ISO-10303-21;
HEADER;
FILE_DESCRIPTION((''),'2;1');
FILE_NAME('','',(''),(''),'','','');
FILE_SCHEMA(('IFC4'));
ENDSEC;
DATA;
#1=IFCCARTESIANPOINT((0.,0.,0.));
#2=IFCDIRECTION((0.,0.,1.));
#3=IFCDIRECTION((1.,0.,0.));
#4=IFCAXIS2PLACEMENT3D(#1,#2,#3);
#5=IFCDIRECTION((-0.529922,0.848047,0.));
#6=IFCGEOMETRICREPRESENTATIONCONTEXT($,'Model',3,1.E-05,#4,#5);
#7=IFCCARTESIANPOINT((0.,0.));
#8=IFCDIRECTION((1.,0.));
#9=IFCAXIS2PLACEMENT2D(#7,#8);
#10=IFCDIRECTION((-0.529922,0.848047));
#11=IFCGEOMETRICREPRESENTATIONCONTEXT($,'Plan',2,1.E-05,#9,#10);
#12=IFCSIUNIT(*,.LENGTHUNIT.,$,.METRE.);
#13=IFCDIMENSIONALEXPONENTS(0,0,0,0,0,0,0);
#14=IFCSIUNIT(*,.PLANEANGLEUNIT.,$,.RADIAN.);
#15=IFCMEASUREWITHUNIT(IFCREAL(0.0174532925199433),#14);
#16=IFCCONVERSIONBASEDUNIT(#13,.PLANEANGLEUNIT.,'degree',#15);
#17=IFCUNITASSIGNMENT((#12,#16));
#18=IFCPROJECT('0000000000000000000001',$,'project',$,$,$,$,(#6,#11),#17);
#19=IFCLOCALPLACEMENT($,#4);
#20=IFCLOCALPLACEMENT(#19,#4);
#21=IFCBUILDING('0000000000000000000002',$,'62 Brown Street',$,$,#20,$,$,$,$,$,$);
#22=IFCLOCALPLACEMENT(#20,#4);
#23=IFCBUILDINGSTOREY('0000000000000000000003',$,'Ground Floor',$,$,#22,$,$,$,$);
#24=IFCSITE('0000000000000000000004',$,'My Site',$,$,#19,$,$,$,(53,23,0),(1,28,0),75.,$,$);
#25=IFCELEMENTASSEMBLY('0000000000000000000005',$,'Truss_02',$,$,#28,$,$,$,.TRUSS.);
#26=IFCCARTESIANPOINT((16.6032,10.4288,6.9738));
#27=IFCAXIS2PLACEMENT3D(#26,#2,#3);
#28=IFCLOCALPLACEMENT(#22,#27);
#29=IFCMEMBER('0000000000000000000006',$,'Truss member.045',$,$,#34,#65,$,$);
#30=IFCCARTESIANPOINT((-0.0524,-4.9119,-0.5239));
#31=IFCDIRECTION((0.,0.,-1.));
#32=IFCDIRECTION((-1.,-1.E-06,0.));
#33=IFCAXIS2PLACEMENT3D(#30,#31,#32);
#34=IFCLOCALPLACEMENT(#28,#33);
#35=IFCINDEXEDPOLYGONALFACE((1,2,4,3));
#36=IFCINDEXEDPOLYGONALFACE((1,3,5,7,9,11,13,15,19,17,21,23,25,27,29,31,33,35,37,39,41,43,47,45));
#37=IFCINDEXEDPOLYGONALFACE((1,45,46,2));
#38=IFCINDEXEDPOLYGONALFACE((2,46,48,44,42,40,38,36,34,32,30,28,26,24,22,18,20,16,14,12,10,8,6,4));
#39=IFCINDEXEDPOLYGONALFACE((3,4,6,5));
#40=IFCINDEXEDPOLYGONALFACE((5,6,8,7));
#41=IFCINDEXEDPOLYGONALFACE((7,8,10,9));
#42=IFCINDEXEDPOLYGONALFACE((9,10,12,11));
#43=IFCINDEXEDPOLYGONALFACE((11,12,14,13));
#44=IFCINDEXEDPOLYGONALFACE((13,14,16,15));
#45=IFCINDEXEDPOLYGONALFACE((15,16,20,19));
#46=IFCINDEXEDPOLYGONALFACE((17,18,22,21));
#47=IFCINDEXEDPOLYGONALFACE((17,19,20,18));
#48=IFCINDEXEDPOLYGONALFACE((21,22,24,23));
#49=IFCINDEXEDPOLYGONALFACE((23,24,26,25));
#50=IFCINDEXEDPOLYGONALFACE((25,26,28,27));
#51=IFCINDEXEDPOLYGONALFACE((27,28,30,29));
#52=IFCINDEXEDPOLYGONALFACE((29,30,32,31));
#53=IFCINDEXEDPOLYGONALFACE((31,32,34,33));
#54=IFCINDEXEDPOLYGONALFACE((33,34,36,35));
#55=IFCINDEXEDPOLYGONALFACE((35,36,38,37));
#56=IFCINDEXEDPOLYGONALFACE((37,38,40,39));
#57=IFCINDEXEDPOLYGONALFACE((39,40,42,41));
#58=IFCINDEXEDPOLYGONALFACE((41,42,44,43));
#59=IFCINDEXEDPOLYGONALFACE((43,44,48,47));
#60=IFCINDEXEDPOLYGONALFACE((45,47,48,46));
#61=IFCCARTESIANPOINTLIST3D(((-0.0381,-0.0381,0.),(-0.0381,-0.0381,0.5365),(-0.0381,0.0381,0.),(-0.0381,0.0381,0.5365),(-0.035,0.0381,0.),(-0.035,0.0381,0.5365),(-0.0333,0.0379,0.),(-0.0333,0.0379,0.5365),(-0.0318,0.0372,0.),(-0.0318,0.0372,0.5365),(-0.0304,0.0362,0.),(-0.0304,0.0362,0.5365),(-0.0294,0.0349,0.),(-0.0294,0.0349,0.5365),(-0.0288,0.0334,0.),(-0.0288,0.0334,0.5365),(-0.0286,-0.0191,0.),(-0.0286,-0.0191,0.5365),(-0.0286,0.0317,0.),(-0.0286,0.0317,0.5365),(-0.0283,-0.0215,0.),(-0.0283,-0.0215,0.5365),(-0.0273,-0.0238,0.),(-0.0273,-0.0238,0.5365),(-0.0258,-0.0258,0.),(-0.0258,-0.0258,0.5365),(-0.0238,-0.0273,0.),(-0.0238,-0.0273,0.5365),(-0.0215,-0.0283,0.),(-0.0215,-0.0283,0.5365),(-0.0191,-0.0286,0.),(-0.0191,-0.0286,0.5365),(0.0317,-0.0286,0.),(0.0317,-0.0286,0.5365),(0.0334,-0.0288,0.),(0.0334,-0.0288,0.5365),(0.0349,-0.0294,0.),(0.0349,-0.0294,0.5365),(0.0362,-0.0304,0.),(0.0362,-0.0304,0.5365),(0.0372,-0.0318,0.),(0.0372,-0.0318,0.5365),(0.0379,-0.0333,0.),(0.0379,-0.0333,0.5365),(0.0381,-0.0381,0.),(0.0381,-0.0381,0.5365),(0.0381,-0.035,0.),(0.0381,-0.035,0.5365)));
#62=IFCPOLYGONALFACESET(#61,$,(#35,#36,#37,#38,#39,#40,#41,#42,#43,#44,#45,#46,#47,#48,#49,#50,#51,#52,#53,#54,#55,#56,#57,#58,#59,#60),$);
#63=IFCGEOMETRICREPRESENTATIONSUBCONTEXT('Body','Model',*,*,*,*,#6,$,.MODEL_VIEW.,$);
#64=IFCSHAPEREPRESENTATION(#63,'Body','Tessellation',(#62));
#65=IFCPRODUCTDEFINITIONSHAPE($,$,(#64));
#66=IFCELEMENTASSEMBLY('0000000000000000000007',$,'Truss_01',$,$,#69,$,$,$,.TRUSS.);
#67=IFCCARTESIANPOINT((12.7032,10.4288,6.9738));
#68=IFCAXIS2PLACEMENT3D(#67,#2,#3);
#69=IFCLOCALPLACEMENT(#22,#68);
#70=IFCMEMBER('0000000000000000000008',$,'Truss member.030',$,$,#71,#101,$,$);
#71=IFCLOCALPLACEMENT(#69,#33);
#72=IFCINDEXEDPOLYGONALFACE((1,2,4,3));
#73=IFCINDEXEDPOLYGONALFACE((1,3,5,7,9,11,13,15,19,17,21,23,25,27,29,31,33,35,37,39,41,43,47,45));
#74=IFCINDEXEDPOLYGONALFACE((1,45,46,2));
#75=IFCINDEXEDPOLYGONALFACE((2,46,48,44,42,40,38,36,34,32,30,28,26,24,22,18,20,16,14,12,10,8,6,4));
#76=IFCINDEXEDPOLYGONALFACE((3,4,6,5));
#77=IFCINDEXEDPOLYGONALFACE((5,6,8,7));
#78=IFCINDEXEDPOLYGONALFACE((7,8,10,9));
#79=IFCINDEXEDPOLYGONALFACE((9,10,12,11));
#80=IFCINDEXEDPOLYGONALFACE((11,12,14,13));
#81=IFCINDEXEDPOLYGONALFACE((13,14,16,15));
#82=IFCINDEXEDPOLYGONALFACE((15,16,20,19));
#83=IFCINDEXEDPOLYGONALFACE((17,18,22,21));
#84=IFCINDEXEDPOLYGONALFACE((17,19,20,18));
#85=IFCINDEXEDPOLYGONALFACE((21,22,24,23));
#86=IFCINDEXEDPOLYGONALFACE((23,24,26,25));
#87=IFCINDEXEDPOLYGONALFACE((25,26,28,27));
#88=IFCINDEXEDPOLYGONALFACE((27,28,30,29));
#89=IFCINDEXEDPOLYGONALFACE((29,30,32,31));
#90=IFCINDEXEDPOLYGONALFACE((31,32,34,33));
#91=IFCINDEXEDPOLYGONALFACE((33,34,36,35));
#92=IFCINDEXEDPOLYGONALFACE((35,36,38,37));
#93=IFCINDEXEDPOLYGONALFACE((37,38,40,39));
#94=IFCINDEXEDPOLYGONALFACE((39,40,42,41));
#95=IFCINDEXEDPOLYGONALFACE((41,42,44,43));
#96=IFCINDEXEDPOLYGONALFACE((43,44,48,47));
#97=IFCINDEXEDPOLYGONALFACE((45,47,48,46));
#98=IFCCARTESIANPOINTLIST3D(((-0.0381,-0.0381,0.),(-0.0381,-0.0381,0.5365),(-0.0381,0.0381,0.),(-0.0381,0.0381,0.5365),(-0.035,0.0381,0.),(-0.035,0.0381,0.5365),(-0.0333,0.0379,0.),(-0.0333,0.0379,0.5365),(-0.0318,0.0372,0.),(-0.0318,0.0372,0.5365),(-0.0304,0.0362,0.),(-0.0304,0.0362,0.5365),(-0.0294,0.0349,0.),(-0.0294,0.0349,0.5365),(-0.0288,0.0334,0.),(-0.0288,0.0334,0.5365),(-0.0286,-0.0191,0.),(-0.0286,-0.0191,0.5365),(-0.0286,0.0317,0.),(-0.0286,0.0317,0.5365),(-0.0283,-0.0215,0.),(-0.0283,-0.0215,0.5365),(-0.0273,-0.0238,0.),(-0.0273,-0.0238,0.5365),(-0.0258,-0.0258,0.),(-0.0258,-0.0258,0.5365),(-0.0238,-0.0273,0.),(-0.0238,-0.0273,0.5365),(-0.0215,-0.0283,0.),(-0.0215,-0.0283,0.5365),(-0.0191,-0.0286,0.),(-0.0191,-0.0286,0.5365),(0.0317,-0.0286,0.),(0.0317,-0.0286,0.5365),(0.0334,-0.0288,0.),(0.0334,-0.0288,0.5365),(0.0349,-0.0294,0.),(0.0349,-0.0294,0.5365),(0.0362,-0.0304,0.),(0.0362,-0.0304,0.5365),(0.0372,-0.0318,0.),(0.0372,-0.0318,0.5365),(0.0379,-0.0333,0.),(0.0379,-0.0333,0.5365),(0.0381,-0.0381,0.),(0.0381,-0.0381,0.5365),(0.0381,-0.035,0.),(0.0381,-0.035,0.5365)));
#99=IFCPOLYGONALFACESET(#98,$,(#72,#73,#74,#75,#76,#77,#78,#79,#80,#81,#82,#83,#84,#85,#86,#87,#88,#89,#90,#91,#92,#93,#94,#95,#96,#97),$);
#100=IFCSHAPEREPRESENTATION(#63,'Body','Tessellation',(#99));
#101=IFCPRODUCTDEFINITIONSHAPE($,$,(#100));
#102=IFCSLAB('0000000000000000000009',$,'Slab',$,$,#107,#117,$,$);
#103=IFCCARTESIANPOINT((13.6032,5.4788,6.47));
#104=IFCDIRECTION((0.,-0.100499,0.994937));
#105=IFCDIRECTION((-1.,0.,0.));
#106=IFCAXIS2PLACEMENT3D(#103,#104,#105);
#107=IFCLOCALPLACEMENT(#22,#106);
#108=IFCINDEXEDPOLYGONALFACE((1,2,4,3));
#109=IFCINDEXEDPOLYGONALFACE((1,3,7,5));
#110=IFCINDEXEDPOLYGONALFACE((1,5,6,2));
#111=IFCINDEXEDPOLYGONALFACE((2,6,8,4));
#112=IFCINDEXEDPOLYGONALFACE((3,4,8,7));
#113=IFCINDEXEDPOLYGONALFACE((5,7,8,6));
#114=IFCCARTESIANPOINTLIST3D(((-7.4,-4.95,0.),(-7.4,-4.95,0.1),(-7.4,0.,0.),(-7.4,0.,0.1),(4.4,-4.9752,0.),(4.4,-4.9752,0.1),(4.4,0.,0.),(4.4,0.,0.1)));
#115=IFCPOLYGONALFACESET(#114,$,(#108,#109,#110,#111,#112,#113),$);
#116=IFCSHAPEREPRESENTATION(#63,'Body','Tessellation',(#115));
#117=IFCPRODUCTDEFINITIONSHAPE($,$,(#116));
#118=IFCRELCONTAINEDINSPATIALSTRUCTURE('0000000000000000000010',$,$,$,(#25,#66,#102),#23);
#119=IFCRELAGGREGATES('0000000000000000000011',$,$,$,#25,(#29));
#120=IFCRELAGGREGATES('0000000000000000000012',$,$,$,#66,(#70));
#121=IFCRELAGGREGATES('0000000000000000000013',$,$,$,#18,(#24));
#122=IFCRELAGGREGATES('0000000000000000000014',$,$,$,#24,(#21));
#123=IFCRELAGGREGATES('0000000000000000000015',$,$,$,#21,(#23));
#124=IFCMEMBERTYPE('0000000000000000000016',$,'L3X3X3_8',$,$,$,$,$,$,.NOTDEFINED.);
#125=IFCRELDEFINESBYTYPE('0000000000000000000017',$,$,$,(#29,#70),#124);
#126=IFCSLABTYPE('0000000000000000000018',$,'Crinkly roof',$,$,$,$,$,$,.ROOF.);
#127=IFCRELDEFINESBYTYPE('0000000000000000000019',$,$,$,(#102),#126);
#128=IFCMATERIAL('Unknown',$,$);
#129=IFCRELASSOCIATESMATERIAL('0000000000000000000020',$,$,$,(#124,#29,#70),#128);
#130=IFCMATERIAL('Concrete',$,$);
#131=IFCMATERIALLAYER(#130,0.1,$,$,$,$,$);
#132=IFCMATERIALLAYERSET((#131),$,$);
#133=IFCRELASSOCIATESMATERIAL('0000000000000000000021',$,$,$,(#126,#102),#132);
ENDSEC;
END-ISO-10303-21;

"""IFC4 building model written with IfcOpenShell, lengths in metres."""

from ifc_helpers import new_model, entity, si_unit, converted_unit, direction, frame, origin_with_axes, origin_2d_with_axis, place, context, subcontext, project, spatial, indexed_curve, l_section, outline, extrude, material, layer, layer_set, layer_usage, material_profile, profile_set, profile_usage, type_object, element, aggregate, save


model = new_model("IFC4")

# Units and contexts
model_context = context("Model", 3, precision=1e-05, world=origin_with_axes(), true_north=direction((-0.529922, 0.848047, 0.0)))
plan_context = context("Plan", 2, precision=1e-05, world=origin_2d_with_axis(), true_north=direction((-0.529922, 0.848047)))
body_context_1 = subcontext(model_context, "Body", "Model", "MODEL_VIEW")
ifc_project = project(units=[si_unit("LENGTHUNIT", "METRE"), converted_unit("PLANEANGLEUNIT", "degree", entity("IfcReal", 0.0174532925199433), si_unit("PLANEANGLEUNIT", "RADIAN"), dimensions=[0, 0, 0, 0, 0, 0, 0])], contexts=[model_context, plan_context])

# Site, building, storey
site_placement = place(None, origin_with_axes())
site = spatial("IfcSite", under=ifc_project, at=site_placement, Name="My Site", RefLatitude=(53, 23, 0), RefLongitude=(1, 28, 0), RefElevation=75.0)
building_placement = place(site_placement, origin_with_axes())
building = spatial("IfcBuilding", under=site, at=building_placement, Name="62 Brown Street")
storey_placement = place(building_placement, origin_with_axes())
storey = spatial("IfcBuildingStorey", under=building, at=storey_placement, Name="Ground Floor")

# Element assemblies, members
ifc_material_1 = material(Name="Unknown")
ifc_material_profile_1 = material_profile(ifc_material_1, l_section(Depth=0.0762, Width=0.0762, Thickness=0.0095, FilletRadius=0.0095, EdgeRadius=0.0064))
ifc_profile_set_1 = profile_set([ifc_material_profile_1])
member_type_1 = type_object("IfcMemberType", Name="L3X3X3_8", PredefinedType="NOTDEFINED", material=ifc_profile_set_1)
assembly_1_placement = place(storey_placement, frame((16.6032, 10.4288, 6.9738), z_axis=(0.0, 0.0, 1.0), x_axis=(1.0, 0.0, 0.0)))
assembly_1 = element("IfcElementAssembly", 1, at=assembly_1_placement, inside=storey, Name="Truss_02", PredefinedType="TRUSS")
ifc_profile_usage_1 = profile_usage(ifc_profile_set_1, cardinal=5)
member_1_placement = place(assembly_1_placement, frame((-0.0524, -4.9119, -0.5239), z_axis=(0.0, 0.0, -1.0), x_axis=(-1.0, -0.000001, 0.0)))
member_1 = element("IfcMember", 2, at=member_1_placement, type_object=member_type_1, material=ifc_profile_usage_1, Name="Truss member.045", context=body_context_1, shape_type="SweptSolid", body=[
    extrude(l_section(Depth=0.0762, Width=0.0762, Thickness=0.0095, FilletRadius=0.0095, EdgeRadius=0.0064), origin_with_axes(), (0.0, 0.0, 1.0), 0.5365),
])
assembly_2_placement = place(storey_placement, frame((12.7032, 10.4288, 6.9738), z_axis=(0.0, 0.0, 1.0), x_axis=(1.0, 0.0, 0.0)))
assembly_2 = element("IfcElementAssembly", 3, at=assembly_2_placement, inside=storey, Name="Truss_01", PredefinedType="TRUSS")
ifc_profile_usage_2 = profile_usage(ifc_profile_set_1, cardinal=5)
member_2_placement = place(assembly_2_placement, frame((-0.0524, -4.9119, -0.5239), z_axis=(0.0, 0.0, -1.0), x_axis=(-1.0, -0.000001, 0.0)))
member_2 = element("IfcMember", 4, at=member_2_placement, type_object=member_type_1, material=ifc_profile_usage_2, Name="Truss member.030", context=body_context_1, shape_type="SweptSolid", body=[
    extrude(l_section(Depth=0.0762, Width=0.0762, Thickness=0.0095, FilletRadius=0.0095, EdgeRadius=0.0064), origin_with_axes(), (0.0, 0.0, 1.0), 0.5365),
])

aggregate(assembly_1, [member_1])
aggregate(assembly_2, [member_2])

# Slab
ifc_material_2 = material(Name="Concrete")
ifc_layer_1 = layer(ifc_material_2, 0.1)
ifc_layer_set_1 = layer_set([ifc_layer_1])
ifc_layer_usage_1 = layer_usage(ifc_layer_set_1, "AXIS3", "POSITIVE", 0.0)
slab_type = type_object("IfcSlabType", Name="Crinkly roof", PredefinedType="ROOF", material=ifc_layer_set_1)
slab_placement = place(storey_placement, frame((13.6032, 5.4788, 6.47), z_axis=(0.0, -0.100499, 0.994937), x_axis=(-1.0, 0.0, 0.0)))
element("IfcSlab", 5, at=slab_placement, inside=storey, type_object=slab_type, material=ifc_layer_usage_1, Name="Slab", context=body_context_1, shape_type="SweptSolid", body=[
    extrude(outline(indexed_curve([(4.4, 0.0), (-7.4, 0.0), (-7.4, -4.95), (4.4, -4.9752), (4.4, 0.0)])), None, (0.0, 0.0, 1.0), 0.1),
])

save(model, "model.ifc")
